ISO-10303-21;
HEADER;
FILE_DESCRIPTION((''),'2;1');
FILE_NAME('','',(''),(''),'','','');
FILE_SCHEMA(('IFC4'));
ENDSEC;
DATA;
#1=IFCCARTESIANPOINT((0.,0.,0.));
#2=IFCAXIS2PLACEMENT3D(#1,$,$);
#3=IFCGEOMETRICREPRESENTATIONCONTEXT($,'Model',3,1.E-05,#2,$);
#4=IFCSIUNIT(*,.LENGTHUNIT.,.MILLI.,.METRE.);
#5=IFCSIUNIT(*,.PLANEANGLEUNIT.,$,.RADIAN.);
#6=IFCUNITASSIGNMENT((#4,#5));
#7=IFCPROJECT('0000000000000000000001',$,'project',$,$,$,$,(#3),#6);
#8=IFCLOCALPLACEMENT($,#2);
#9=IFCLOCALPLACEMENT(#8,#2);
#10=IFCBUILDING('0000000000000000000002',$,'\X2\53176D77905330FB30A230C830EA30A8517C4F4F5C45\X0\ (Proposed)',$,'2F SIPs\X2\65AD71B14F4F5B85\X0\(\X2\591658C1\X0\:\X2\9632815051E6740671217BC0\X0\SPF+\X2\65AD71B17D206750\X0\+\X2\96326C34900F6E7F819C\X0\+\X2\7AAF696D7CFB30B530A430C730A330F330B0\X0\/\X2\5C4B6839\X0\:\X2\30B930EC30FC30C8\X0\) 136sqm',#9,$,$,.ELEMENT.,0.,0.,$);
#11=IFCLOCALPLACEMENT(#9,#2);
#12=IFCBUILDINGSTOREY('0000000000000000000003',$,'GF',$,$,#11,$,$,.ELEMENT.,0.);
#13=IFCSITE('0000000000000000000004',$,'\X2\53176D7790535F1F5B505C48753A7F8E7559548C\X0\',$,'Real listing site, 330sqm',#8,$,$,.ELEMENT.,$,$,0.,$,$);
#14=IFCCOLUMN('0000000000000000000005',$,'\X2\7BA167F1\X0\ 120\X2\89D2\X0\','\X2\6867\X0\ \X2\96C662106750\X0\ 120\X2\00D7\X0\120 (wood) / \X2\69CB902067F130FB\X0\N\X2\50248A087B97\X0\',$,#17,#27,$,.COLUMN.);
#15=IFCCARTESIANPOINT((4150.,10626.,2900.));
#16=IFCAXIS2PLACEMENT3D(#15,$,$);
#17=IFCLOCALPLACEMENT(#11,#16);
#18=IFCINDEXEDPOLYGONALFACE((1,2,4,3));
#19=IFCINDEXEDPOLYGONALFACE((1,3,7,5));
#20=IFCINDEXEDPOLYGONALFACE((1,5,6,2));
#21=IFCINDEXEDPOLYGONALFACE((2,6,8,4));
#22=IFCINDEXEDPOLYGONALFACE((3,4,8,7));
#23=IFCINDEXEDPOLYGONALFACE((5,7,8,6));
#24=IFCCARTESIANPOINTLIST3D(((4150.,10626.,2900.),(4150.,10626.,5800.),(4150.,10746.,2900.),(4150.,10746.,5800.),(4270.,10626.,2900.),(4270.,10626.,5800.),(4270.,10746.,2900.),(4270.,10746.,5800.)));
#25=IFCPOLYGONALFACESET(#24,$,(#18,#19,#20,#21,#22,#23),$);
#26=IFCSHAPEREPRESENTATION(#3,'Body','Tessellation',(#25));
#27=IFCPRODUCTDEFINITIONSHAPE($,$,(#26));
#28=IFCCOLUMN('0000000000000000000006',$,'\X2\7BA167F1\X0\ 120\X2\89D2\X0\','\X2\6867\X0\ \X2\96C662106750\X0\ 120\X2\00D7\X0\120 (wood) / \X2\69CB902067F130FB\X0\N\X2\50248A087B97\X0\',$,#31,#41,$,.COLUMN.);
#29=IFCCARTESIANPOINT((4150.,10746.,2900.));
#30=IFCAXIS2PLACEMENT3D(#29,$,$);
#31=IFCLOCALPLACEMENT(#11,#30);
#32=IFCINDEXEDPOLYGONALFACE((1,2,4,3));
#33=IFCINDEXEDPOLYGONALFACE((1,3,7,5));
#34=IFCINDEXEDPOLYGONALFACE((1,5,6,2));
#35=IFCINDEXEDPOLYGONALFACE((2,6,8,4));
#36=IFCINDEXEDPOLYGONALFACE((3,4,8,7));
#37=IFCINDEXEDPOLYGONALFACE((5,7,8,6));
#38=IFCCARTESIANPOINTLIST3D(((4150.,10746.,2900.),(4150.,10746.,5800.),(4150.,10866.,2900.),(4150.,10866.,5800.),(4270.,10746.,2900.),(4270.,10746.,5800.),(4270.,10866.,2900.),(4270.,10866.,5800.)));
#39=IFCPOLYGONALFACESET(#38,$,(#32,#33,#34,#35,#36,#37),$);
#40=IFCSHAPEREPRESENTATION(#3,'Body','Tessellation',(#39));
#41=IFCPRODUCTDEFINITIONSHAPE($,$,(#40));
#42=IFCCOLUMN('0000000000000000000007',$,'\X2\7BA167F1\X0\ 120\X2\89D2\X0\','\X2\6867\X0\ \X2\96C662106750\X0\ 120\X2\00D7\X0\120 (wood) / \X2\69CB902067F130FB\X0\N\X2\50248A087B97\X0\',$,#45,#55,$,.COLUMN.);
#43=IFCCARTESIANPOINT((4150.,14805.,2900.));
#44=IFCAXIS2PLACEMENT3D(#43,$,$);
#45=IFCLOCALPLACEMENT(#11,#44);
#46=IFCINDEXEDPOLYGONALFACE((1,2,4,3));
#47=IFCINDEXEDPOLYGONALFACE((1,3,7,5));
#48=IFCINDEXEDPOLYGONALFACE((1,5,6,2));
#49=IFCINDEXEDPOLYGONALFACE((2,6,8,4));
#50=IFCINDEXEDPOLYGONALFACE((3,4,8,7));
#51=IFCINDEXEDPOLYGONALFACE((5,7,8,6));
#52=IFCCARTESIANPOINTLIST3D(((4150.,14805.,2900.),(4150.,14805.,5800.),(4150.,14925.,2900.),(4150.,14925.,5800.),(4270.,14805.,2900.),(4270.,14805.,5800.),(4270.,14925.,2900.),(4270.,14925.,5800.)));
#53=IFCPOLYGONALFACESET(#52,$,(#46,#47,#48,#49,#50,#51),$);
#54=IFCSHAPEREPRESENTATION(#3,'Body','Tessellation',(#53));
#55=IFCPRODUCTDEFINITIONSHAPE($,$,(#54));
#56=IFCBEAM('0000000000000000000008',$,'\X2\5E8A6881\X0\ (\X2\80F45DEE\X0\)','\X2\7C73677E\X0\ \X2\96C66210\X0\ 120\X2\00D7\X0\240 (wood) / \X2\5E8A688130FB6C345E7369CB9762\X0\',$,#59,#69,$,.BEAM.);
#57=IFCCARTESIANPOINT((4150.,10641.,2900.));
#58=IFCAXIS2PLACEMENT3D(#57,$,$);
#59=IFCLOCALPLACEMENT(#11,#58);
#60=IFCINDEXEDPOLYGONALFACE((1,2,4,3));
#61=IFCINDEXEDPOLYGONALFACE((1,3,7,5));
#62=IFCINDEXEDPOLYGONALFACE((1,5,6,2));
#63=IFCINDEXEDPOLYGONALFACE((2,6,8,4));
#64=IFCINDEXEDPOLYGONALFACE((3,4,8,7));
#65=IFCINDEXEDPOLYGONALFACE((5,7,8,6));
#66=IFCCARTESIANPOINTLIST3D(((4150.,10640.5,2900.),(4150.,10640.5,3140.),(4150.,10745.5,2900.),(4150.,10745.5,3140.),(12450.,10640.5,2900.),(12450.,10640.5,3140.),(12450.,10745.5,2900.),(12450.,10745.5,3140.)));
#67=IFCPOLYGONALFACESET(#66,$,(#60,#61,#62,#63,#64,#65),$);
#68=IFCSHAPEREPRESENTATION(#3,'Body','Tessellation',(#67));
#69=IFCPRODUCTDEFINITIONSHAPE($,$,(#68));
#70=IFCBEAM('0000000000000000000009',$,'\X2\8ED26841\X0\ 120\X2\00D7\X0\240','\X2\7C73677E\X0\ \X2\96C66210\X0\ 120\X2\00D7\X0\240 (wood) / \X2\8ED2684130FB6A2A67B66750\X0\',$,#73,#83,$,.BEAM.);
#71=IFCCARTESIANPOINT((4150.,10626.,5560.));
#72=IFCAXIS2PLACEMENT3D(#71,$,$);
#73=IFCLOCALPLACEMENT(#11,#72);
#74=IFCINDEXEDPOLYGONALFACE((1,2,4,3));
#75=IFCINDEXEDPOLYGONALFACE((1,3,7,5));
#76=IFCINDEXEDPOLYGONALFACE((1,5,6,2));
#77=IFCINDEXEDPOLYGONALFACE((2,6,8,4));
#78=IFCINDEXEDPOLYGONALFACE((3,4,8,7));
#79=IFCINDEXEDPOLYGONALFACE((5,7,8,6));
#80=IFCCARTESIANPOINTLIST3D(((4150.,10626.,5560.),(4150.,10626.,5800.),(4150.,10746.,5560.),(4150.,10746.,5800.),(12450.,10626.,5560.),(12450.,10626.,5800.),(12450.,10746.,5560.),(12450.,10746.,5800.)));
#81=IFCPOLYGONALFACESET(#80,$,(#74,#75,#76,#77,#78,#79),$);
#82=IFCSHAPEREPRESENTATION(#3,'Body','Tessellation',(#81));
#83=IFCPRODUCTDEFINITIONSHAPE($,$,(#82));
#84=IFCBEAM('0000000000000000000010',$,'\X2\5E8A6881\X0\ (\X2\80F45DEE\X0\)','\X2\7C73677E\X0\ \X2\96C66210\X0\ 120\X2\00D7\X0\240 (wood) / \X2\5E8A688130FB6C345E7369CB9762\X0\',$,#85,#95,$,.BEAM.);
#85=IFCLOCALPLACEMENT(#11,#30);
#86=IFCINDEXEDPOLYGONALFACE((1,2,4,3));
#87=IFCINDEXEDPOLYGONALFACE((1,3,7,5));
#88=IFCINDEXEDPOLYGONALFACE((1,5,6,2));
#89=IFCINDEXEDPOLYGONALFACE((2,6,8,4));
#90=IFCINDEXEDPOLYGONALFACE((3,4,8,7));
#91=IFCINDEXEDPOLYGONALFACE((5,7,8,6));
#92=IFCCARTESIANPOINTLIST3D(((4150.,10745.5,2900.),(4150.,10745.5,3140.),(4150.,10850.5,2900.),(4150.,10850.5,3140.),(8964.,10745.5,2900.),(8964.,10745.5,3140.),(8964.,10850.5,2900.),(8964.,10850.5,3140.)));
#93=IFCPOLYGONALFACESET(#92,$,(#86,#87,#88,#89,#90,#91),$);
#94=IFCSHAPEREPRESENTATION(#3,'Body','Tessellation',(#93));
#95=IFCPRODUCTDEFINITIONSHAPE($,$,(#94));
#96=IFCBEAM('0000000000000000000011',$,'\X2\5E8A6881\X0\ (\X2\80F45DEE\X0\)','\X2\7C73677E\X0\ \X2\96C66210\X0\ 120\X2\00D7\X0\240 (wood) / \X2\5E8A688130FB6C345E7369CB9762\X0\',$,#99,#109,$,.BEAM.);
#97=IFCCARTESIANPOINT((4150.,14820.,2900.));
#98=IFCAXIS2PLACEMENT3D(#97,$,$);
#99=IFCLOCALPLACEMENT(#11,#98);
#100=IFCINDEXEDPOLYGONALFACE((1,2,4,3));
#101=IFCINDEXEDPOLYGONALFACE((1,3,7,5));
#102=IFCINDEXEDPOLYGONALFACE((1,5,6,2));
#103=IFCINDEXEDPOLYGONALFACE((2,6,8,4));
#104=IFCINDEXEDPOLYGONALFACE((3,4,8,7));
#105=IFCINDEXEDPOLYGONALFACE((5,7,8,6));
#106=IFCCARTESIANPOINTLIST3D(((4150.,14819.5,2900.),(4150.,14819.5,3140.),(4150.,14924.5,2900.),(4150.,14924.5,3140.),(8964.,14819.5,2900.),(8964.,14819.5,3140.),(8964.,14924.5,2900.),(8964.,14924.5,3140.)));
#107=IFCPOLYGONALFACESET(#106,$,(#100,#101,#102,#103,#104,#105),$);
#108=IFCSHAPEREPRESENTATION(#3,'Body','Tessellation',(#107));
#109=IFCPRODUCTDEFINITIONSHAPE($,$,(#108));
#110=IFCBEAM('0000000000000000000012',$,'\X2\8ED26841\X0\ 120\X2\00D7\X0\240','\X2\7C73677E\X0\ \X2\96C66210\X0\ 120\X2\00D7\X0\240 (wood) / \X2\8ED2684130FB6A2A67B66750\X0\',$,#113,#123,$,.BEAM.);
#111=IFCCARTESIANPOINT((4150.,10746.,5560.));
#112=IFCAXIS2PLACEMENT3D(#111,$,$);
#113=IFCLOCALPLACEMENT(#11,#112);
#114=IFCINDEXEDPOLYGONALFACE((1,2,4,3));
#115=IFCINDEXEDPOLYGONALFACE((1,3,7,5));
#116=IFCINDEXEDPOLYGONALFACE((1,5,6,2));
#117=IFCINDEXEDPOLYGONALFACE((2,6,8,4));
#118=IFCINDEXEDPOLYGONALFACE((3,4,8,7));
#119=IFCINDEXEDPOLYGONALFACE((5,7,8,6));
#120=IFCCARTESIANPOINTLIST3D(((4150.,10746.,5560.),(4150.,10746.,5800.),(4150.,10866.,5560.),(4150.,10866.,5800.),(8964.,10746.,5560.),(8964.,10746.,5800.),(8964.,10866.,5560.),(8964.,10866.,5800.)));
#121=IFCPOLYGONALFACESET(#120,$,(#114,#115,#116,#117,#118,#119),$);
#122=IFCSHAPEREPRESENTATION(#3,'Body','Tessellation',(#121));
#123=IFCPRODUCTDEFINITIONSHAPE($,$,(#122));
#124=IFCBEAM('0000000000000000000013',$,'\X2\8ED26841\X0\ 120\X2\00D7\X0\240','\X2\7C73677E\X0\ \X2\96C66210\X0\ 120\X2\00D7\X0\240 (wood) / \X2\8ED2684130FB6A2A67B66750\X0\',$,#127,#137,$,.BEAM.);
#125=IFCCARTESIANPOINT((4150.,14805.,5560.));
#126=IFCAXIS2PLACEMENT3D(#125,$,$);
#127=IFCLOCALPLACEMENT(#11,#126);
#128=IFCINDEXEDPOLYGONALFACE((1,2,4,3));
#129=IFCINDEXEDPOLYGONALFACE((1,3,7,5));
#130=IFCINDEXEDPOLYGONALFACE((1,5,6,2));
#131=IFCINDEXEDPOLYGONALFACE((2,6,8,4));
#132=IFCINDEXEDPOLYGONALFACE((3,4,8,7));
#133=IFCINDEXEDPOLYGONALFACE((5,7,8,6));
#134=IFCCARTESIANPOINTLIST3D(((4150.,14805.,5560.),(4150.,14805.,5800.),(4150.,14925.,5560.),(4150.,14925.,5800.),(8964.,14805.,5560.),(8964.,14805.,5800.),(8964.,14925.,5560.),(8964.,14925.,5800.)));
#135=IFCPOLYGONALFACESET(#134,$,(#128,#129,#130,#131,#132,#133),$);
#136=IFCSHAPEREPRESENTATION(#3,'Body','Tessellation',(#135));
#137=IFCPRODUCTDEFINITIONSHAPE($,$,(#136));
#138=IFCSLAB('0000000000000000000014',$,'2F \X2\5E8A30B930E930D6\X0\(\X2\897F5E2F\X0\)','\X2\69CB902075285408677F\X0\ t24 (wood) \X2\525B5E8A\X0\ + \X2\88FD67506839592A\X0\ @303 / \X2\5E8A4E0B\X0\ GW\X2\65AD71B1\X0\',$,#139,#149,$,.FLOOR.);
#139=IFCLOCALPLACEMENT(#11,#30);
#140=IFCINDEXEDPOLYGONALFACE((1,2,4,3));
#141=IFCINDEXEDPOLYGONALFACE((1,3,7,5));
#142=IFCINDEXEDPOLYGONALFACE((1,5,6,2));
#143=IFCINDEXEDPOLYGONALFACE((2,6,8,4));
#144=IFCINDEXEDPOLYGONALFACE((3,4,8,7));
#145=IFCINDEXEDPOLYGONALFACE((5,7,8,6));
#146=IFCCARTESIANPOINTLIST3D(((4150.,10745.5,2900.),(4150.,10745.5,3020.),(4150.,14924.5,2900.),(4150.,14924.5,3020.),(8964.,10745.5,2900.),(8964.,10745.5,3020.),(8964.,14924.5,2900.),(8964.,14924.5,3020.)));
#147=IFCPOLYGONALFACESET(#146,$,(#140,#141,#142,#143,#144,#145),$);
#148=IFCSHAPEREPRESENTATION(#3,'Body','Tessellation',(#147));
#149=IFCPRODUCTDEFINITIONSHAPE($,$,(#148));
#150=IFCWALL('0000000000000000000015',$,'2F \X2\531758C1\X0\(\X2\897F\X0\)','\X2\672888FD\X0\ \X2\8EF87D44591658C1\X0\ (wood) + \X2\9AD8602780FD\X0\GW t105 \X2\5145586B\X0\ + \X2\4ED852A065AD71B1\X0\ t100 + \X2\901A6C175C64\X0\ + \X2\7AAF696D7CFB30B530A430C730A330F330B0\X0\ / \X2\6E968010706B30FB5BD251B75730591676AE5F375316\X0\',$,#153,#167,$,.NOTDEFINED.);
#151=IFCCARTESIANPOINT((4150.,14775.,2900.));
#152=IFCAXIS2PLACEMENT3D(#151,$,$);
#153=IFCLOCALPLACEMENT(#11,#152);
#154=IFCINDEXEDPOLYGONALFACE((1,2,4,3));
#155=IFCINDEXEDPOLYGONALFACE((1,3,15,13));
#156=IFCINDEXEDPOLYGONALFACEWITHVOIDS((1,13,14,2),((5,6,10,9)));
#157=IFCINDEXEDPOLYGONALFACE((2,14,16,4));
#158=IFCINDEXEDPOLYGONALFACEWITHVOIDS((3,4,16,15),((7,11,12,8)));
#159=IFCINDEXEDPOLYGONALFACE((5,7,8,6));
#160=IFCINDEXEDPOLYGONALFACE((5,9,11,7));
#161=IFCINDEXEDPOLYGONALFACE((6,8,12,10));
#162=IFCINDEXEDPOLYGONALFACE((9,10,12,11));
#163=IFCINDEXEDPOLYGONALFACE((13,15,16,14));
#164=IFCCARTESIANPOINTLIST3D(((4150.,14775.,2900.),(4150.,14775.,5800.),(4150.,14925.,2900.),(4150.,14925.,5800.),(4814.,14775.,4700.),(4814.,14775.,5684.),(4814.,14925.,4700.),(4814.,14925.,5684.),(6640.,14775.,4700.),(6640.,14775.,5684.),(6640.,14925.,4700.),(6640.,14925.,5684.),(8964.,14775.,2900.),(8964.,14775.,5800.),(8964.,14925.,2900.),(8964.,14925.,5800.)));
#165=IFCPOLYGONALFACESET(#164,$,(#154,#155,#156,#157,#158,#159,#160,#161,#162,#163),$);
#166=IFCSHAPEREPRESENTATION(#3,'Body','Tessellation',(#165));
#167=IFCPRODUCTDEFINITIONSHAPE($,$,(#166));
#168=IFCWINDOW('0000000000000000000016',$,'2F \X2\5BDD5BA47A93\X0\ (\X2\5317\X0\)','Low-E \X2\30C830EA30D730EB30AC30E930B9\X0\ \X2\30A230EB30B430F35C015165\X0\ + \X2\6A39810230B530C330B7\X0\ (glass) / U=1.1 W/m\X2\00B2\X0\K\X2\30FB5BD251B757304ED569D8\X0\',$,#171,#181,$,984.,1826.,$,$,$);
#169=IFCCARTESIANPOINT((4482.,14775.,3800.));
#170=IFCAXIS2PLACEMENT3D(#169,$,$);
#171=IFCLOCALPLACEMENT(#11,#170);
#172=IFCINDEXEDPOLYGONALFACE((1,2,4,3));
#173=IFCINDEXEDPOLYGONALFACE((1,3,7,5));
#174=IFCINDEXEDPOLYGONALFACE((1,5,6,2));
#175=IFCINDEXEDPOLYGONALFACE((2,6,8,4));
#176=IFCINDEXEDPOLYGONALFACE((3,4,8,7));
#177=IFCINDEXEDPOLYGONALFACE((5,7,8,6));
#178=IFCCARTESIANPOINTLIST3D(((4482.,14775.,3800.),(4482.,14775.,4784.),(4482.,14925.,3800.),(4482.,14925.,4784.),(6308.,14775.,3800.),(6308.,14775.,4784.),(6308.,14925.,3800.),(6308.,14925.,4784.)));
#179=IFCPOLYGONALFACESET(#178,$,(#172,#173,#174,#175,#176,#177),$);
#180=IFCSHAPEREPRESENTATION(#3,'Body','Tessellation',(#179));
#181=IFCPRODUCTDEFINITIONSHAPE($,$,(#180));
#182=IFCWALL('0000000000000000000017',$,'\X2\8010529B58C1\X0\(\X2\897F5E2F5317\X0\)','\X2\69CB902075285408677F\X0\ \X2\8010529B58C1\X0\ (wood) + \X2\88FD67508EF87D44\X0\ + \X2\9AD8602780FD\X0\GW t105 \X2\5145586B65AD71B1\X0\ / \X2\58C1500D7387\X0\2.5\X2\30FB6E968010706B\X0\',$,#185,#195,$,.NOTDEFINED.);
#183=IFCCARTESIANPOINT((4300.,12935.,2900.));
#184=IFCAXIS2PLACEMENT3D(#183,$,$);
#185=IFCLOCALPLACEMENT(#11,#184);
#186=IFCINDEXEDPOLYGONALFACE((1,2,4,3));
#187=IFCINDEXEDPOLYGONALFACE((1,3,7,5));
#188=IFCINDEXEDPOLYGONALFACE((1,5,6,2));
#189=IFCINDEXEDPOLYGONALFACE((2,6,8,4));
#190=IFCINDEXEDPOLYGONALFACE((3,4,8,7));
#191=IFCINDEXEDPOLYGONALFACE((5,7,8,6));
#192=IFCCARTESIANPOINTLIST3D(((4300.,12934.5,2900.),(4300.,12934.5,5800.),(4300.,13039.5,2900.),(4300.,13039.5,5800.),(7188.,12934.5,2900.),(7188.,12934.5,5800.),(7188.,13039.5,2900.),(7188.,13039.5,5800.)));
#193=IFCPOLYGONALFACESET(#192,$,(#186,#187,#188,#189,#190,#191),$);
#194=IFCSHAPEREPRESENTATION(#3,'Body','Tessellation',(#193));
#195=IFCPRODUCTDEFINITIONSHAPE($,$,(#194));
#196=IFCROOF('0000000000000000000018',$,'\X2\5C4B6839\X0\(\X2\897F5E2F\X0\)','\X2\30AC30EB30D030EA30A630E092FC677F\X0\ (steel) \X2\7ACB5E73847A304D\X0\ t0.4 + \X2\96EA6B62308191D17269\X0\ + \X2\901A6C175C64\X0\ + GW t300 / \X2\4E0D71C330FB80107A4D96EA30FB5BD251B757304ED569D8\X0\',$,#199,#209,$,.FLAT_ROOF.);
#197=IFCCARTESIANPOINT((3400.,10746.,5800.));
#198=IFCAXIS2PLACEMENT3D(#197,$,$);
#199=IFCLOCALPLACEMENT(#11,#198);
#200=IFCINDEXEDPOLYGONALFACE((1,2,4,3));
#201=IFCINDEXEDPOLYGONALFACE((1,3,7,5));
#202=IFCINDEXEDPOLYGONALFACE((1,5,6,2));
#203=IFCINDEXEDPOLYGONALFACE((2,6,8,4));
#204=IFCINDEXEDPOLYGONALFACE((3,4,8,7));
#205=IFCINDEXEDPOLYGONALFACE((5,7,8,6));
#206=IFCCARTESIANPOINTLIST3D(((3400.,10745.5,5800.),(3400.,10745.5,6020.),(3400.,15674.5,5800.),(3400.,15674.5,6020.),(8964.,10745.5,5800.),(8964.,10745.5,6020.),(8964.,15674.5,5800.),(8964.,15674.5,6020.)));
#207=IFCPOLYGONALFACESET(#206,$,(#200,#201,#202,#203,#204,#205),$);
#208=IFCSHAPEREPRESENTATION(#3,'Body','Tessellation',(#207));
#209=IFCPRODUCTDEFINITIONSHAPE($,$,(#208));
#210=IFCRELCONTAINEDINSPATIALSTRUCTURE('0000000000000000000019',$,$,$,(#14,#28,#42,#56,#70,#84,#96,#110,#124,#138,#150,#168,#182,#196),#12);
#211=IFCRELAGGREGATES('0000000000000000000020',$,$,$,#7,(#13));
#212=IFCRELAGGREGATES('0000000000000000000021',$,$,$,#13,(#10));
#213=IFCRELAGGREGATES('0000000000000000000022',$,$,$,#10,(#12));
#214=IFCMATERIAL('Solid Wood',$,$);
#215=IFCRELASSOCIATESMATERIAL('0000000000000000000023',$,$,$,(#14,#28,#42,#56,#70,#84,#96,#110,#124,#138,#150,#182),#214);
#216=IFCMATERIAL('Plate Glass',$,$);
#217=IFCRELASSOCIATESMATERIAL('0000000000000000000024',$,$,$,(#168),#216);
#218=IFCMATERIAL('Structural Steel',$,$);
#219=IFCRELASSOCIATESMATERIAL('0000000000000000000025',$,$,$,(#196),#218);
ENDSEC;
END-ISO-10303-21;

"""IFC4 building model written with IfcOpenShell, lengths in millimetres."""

from ifc_helpers import new_model, si_unit, frame, frame_2d, origin, place, context, project, spatial, rectangle, extrude, material, element, fill, save


model = new_model("IFC4")

# Units and contexts
model_context = context("Model", 3, precision=1e-05, world=origin())
ifc_project = project(units=[si_unit("LENGTHUNIT", "METRE", prefix="MILLI"), si_unit("PLANEANGLEUNIT", "RADIAN")], contexts=[model_context])

# Site, building, storey
site_placement = place(None, origin())
site = spatial("IfcSite", under=ifc_project, at=site_placement, Name="北海道弟子屈町美留和", ObjectType="Real listing site, 330sqm", CompositionType="ELEMENT", RefElevation=0.0)
building_placement = place(site_placement, origin())
building = spatial("IfcBuilding", under=site, at=building_placement, Name="北海道・アトリエ兼住居 (Proposed)", ObjectType="2F SIPs断熱住宅(外壁:防腐処理無節SPF+断熱素材+防水透湿膜+窯業系サイディング/屋根:スレート) 136sqm", CompositionType="ELEMENT", ElevationOfRefHeight=0.0, ElevationOfTerrain=0.0)
storey_placement = place(building_placement, origin())
storey = spatial("IfcBuildingStorey", under=building, at=storey_placement, Name="GF", CompositionType="ELEMENT", Elevation=0.0)

# Columns
ifc_material_1 = material(Name="Solid Wood")
column_1_placement = place(storey_placement, frame((4150.0, 10626.0, 2900.0)))
element("IfcColumn", 1, at=column_1_placement, inside=storey, material=ifc_material_1, Name="管柱 120角", Description="桧 集成材 120×120 (wood) / 構造柱・N値計算", PredefinedType="COLUMN", context=model_context, shape_type="SweptSolid", body=[
    extrude(rectangle(XDim=120.0, YDim=120.0, at=frame_2d((60.0, 60.0))), frame((4150.0, 10626.0, 2900.0)), (0.0, 0.0, 1.0), 2900.0),
])
column_2_placement = place(storey_placement, frame((4150.0, 10746.0, 2900.0)))
element("IfcColumn", 2, at=column_2_placement, inside=storey, material=ifc_material_1, Name="管柱 120角", Description="桧 集成材 120×120 (wood) / 構造柱・N値計算", PredefinedType="COLUMN", context=model_context, shape_type="SweptSolid", body=[
    extrude(rectangle(XDim=120.0, YDim=120.0, at=frame_2d((60.0, 60.0))), frame((4150.0, 10746.0, 2900.0)), (0.0, 0.0, 1.0), 2900.0),
])
column_3_placement = place(storey_placement, frame((4150.0, 14805.0, 2900.0)))
element("IfcColumn", 3, at=column_3_placement, inside=storey, material=ifc_material_1, Name="管柱 120角", Description="桧 集成材 120×120 (wood) / 構造柱・N値計算", PredefinedType="COLUMN", context=model_context, shape_type="SweptSolid", body=[
    extrude(rectangle(XDim=120.0, YDim=120.0, at=frame_2d((60.0, 60.0))), frame((4150.0, 14805.0, 2900.0)), (0.0, 0.0, 1.0), 2900.0),
])

# Beams
beam_1_placement = place(storey_placement, frame((4150.0, 10641.0, 2900.0)))
element("IfcBeam", 4, at=beam_1_placement, inside=storey, material=ifc_material_1, Name="床梁 (胴差)", Description="米松 集成 120×240 (wood) / 床梁・水平構面", PredefinedType="BEAM", context=model_context, shape_type="SweptSolid", body=[
    extrude(rectangle(XDim=8300.0, YDim=105.0, at=frame_2d((4150.0, 52.0))), frame((4150.0, 10641.0, 2900.0)), (0.0, 0.0, 1.0), 240.0),
])
beam_2_placement = place(storey_placement, frame((4150.0, 10626.0, 5560.0)))
element("IfcBeam", 5, at=beam_2_placement, inside=storey, material=ifc_material_1, Name="軒桁 120×240", Description="米松 集成 120×240 (wood) / 軒桁・横架材", PredefinedType="BEAM", context=model_context, shape_type="SweptSolid", body=[
    extrude(rectangle(XDim=8300.0, YDim=120.0, at=frame_2d((4150.0, 60.0))), frame((4150.0, 10626.0, 5560.0)), (0.0, 0.0, 1.0), 240.0),
])
beam_3_placement = place(storey_placement, frame((4150.0, 10746.0, 2900.0)))
element("IfcBeam", 6, at=beam_3_placement, inside=storey, material=ifc_material_1, Name="床梁 (胴差)", Description="米松 集成 120×240 (wood) / 床梁・水平構面", PredefinedType="BEAM", context=model_context, shape_type="SweptSolid", body=[
    extrude(rectangle(XDim=4814.0, YDim=105.0, at=frame_2d((2407.0, 52.0))), frame((4150.0, 10746.0, 2900.0)), (0.0, 0.0, 1.0), 240.0),
])
beam_4_placement = place(storey_placement, frame((4150.0, 14820.0, 2900.0)))
element("IfcBeam", 7, at=beam_4_placement, inside=storey, material=ifc_material_1, Name="床梁 (胴差)", Description="米松 集成 120×240 (wood) / 床梁・水平構面", PredefinedType="BEAM", context=model_context, shape_type="SweptSolid", body=[
    extrude(rectangle(XDim=4814.0, YDim=105.0, at=frame_2d((2407.0, 52.0))), frame((4150.0, 14820.0, 2900.0)), (0.0, 0.0, 1.0), 240.0),
])
beam_5_placement = place(storey_placement, frame((4150.0, 10746.0, 5560.0)))
element("IfcBeam", 8, at=beam_5_placement, inside=storey, material=ifc_material_1, Name="軒桁 120×240", Description="米松 集成 120×240 (wood) / 軒桁・横架材", PredefinedType="BEAM", context=model_context, shape_type="SweptSolid", body=[
    extrude(rectangle(XDim=4814.0, YDim=120.0, at=frame_2d((2407.0, 60.0))), frame((4150.0, 10746.0, 5560.0)), (0.0, 0.0, 1.0), 240.0),
])
beam_6_placement = place(storey_placement, frame((4150.0, 14805.0, 5560.0)))
element("IfcBeam", 9, at=beam_6_placement, inside=storey, material=ifc_material_1, Name="軒桁 120×240", Description="米松 集成 120×240 (wood) / 軒桁・横架材", PredefinedType="BEAM", context=model_context, shape_type="SweptSolid", body=[
    extrude(rectangle(XDim=4814.0, YDim=120.0, at=frame_2d((2407.0, 60.0))), frame((4150.0, 14805.0, 5560.0)), (0.0, 0.0, 1.0), 240.0),
])

# Slab
slab_placement = place(storey_placement, frame((4150.0, 10746.0, 2900.0)))
element("IfcSlab", 10, at=slab_placement, inside=storey, material=ifc_material_1, Name="2F 床スラブ(西帯)", Description="構造用合板 t24 (wood) 剛床 + 製材根太 @303 / 床下 GW断熱", PredefinedType="FLOOR", context=model_context, shape_type="SweptSolid", body=[
    extrude(rectangle(XDim=4814.0, YDim=4179.0, at=frame_2d((2407.0, 2089.0))), frame((4150.0, 10746.0, 2900.0)), (0.0, 0.0, 1.0), 120.0),
])

# Wall, opening, window
wall_1_placement = place(storey_placement, frame((4150.0, 14775.0, 2900.0)))
wall_1 = element("IfcWall", 11, at=wall_1_placement, inside=storey, material=ifc_material_1, Name="2F 北壁(西)", Description="木製 軸組外壁 (wood) + 高性能GW t105 充填 + 付加断熱 t100 + 通気層 + 窯業系サイディング / 準耐火・寒冷地外皮強化", PredefinedType="NOTDEFINED", context=model_context, shape_type="SweptSolid", body=[
    extrude(rectangle(XDim=4814.0, YDim=150.0, at=frame_2d((2407.0, 75.0))), frame((4150.0, 14775.0, 2900.0)), (0.0, 0.0, 1.0), 2900.0),
])
opening_placement = place(storey_placement, frame((4482.0, 14775.0, 3800.0)))
opening = element("IfcOpeningElement", 12, at=opening_placement, cuts=wall_1, PredefinedType="NOTDEFINED", context=model_context, shape_type="SweptSolid", body=[
    extrude(rectangle(XDim=1826.0, YDim=150.0, at=frame_2d((913.0, 75.0))), frame((4482.0, 14775.0, 3800.0)), (0.0, 0.0, 1.0), 984.0),
])
ifc_material_2 = material(Name="Plate Glass")
window_placement = place(storey_placement, frame((4482.0, 14775.0, 3800.0)))
window = element("IfcWindow", 13, at=window_placement, inside=storey, material=ifc_material_2, Name="2F 寝室窓 (北)", Description="Low-E トリプルガラス アルゴン封入 + 樹脂サッシ (glass) / U=1.1 W/m²K・寒冷地仕様", OverallHeight=984.0, OverallWidth=1826.0, context=model_context, shape_type="SweptSolid", body=[
    extrude(rectangle(XDim=1826.0, YDim=150.0, at=frame_2d((913.0, 75.0))), frame((4482.0, 14775.0, 3800.0)), (0.0, 0.0, 1.0), 984.0),
])
fill(opening, window)

# Wall
wall_2_placement = place(storey_placement, frame((4300.0, 12935.0, 2900.0)))
element("IfcWall", 14, at=wall_2_placement, inside=storey, material=ifc_material_1, Name="耐力壁(西帯北)", Description="構造用合板 耐力壁 (wood) + 製材軸組 + 高性能GW t105 充填断熱 / 壁倍率2.5・準耐火", PredefinedType="NOTDEFINED", context=model_context, shape_type="SweptSolid", body=[
    extrude(rectangle(XDim=2888.0, YDim=105.0, at=frame_2d((1444.0, 52.0))), frame((4300.0, 12935.0, 2900.0)), (0.0, 0.0, 1.0), 2900.0),
])

# Roof
ifc_material_3 = material(Name="Structural Steel")
for number, where, name in (
    (15, (3400.0, 10746.0, 5800.0), "屋根(西帯)"),
):
    element("IfcRoof", number, at=place(storey_placement, frame(where)), inside=storey, material=ifc_material_3, Name=name, Description="ガルバリウム鋼板 (steel) 立平葺き t0.4 + 雪止め金物 + 通気層 + GW t300 / 不燃・耐積雪・寒冷地仕様", PredefinedType="FLAT_ROOF", context=model_context, shape_type="SweptSolid", body=[
        extrude(rectangle(XDim=5564.0, YDim=4929.0, at=frame_2d((2782.0, 2464.0))), frame((3400.0, 10746.0, 5800.0)), (0.0, 0.0, 1.0), 220.0),
    ])

save(model, "model.ifc")
